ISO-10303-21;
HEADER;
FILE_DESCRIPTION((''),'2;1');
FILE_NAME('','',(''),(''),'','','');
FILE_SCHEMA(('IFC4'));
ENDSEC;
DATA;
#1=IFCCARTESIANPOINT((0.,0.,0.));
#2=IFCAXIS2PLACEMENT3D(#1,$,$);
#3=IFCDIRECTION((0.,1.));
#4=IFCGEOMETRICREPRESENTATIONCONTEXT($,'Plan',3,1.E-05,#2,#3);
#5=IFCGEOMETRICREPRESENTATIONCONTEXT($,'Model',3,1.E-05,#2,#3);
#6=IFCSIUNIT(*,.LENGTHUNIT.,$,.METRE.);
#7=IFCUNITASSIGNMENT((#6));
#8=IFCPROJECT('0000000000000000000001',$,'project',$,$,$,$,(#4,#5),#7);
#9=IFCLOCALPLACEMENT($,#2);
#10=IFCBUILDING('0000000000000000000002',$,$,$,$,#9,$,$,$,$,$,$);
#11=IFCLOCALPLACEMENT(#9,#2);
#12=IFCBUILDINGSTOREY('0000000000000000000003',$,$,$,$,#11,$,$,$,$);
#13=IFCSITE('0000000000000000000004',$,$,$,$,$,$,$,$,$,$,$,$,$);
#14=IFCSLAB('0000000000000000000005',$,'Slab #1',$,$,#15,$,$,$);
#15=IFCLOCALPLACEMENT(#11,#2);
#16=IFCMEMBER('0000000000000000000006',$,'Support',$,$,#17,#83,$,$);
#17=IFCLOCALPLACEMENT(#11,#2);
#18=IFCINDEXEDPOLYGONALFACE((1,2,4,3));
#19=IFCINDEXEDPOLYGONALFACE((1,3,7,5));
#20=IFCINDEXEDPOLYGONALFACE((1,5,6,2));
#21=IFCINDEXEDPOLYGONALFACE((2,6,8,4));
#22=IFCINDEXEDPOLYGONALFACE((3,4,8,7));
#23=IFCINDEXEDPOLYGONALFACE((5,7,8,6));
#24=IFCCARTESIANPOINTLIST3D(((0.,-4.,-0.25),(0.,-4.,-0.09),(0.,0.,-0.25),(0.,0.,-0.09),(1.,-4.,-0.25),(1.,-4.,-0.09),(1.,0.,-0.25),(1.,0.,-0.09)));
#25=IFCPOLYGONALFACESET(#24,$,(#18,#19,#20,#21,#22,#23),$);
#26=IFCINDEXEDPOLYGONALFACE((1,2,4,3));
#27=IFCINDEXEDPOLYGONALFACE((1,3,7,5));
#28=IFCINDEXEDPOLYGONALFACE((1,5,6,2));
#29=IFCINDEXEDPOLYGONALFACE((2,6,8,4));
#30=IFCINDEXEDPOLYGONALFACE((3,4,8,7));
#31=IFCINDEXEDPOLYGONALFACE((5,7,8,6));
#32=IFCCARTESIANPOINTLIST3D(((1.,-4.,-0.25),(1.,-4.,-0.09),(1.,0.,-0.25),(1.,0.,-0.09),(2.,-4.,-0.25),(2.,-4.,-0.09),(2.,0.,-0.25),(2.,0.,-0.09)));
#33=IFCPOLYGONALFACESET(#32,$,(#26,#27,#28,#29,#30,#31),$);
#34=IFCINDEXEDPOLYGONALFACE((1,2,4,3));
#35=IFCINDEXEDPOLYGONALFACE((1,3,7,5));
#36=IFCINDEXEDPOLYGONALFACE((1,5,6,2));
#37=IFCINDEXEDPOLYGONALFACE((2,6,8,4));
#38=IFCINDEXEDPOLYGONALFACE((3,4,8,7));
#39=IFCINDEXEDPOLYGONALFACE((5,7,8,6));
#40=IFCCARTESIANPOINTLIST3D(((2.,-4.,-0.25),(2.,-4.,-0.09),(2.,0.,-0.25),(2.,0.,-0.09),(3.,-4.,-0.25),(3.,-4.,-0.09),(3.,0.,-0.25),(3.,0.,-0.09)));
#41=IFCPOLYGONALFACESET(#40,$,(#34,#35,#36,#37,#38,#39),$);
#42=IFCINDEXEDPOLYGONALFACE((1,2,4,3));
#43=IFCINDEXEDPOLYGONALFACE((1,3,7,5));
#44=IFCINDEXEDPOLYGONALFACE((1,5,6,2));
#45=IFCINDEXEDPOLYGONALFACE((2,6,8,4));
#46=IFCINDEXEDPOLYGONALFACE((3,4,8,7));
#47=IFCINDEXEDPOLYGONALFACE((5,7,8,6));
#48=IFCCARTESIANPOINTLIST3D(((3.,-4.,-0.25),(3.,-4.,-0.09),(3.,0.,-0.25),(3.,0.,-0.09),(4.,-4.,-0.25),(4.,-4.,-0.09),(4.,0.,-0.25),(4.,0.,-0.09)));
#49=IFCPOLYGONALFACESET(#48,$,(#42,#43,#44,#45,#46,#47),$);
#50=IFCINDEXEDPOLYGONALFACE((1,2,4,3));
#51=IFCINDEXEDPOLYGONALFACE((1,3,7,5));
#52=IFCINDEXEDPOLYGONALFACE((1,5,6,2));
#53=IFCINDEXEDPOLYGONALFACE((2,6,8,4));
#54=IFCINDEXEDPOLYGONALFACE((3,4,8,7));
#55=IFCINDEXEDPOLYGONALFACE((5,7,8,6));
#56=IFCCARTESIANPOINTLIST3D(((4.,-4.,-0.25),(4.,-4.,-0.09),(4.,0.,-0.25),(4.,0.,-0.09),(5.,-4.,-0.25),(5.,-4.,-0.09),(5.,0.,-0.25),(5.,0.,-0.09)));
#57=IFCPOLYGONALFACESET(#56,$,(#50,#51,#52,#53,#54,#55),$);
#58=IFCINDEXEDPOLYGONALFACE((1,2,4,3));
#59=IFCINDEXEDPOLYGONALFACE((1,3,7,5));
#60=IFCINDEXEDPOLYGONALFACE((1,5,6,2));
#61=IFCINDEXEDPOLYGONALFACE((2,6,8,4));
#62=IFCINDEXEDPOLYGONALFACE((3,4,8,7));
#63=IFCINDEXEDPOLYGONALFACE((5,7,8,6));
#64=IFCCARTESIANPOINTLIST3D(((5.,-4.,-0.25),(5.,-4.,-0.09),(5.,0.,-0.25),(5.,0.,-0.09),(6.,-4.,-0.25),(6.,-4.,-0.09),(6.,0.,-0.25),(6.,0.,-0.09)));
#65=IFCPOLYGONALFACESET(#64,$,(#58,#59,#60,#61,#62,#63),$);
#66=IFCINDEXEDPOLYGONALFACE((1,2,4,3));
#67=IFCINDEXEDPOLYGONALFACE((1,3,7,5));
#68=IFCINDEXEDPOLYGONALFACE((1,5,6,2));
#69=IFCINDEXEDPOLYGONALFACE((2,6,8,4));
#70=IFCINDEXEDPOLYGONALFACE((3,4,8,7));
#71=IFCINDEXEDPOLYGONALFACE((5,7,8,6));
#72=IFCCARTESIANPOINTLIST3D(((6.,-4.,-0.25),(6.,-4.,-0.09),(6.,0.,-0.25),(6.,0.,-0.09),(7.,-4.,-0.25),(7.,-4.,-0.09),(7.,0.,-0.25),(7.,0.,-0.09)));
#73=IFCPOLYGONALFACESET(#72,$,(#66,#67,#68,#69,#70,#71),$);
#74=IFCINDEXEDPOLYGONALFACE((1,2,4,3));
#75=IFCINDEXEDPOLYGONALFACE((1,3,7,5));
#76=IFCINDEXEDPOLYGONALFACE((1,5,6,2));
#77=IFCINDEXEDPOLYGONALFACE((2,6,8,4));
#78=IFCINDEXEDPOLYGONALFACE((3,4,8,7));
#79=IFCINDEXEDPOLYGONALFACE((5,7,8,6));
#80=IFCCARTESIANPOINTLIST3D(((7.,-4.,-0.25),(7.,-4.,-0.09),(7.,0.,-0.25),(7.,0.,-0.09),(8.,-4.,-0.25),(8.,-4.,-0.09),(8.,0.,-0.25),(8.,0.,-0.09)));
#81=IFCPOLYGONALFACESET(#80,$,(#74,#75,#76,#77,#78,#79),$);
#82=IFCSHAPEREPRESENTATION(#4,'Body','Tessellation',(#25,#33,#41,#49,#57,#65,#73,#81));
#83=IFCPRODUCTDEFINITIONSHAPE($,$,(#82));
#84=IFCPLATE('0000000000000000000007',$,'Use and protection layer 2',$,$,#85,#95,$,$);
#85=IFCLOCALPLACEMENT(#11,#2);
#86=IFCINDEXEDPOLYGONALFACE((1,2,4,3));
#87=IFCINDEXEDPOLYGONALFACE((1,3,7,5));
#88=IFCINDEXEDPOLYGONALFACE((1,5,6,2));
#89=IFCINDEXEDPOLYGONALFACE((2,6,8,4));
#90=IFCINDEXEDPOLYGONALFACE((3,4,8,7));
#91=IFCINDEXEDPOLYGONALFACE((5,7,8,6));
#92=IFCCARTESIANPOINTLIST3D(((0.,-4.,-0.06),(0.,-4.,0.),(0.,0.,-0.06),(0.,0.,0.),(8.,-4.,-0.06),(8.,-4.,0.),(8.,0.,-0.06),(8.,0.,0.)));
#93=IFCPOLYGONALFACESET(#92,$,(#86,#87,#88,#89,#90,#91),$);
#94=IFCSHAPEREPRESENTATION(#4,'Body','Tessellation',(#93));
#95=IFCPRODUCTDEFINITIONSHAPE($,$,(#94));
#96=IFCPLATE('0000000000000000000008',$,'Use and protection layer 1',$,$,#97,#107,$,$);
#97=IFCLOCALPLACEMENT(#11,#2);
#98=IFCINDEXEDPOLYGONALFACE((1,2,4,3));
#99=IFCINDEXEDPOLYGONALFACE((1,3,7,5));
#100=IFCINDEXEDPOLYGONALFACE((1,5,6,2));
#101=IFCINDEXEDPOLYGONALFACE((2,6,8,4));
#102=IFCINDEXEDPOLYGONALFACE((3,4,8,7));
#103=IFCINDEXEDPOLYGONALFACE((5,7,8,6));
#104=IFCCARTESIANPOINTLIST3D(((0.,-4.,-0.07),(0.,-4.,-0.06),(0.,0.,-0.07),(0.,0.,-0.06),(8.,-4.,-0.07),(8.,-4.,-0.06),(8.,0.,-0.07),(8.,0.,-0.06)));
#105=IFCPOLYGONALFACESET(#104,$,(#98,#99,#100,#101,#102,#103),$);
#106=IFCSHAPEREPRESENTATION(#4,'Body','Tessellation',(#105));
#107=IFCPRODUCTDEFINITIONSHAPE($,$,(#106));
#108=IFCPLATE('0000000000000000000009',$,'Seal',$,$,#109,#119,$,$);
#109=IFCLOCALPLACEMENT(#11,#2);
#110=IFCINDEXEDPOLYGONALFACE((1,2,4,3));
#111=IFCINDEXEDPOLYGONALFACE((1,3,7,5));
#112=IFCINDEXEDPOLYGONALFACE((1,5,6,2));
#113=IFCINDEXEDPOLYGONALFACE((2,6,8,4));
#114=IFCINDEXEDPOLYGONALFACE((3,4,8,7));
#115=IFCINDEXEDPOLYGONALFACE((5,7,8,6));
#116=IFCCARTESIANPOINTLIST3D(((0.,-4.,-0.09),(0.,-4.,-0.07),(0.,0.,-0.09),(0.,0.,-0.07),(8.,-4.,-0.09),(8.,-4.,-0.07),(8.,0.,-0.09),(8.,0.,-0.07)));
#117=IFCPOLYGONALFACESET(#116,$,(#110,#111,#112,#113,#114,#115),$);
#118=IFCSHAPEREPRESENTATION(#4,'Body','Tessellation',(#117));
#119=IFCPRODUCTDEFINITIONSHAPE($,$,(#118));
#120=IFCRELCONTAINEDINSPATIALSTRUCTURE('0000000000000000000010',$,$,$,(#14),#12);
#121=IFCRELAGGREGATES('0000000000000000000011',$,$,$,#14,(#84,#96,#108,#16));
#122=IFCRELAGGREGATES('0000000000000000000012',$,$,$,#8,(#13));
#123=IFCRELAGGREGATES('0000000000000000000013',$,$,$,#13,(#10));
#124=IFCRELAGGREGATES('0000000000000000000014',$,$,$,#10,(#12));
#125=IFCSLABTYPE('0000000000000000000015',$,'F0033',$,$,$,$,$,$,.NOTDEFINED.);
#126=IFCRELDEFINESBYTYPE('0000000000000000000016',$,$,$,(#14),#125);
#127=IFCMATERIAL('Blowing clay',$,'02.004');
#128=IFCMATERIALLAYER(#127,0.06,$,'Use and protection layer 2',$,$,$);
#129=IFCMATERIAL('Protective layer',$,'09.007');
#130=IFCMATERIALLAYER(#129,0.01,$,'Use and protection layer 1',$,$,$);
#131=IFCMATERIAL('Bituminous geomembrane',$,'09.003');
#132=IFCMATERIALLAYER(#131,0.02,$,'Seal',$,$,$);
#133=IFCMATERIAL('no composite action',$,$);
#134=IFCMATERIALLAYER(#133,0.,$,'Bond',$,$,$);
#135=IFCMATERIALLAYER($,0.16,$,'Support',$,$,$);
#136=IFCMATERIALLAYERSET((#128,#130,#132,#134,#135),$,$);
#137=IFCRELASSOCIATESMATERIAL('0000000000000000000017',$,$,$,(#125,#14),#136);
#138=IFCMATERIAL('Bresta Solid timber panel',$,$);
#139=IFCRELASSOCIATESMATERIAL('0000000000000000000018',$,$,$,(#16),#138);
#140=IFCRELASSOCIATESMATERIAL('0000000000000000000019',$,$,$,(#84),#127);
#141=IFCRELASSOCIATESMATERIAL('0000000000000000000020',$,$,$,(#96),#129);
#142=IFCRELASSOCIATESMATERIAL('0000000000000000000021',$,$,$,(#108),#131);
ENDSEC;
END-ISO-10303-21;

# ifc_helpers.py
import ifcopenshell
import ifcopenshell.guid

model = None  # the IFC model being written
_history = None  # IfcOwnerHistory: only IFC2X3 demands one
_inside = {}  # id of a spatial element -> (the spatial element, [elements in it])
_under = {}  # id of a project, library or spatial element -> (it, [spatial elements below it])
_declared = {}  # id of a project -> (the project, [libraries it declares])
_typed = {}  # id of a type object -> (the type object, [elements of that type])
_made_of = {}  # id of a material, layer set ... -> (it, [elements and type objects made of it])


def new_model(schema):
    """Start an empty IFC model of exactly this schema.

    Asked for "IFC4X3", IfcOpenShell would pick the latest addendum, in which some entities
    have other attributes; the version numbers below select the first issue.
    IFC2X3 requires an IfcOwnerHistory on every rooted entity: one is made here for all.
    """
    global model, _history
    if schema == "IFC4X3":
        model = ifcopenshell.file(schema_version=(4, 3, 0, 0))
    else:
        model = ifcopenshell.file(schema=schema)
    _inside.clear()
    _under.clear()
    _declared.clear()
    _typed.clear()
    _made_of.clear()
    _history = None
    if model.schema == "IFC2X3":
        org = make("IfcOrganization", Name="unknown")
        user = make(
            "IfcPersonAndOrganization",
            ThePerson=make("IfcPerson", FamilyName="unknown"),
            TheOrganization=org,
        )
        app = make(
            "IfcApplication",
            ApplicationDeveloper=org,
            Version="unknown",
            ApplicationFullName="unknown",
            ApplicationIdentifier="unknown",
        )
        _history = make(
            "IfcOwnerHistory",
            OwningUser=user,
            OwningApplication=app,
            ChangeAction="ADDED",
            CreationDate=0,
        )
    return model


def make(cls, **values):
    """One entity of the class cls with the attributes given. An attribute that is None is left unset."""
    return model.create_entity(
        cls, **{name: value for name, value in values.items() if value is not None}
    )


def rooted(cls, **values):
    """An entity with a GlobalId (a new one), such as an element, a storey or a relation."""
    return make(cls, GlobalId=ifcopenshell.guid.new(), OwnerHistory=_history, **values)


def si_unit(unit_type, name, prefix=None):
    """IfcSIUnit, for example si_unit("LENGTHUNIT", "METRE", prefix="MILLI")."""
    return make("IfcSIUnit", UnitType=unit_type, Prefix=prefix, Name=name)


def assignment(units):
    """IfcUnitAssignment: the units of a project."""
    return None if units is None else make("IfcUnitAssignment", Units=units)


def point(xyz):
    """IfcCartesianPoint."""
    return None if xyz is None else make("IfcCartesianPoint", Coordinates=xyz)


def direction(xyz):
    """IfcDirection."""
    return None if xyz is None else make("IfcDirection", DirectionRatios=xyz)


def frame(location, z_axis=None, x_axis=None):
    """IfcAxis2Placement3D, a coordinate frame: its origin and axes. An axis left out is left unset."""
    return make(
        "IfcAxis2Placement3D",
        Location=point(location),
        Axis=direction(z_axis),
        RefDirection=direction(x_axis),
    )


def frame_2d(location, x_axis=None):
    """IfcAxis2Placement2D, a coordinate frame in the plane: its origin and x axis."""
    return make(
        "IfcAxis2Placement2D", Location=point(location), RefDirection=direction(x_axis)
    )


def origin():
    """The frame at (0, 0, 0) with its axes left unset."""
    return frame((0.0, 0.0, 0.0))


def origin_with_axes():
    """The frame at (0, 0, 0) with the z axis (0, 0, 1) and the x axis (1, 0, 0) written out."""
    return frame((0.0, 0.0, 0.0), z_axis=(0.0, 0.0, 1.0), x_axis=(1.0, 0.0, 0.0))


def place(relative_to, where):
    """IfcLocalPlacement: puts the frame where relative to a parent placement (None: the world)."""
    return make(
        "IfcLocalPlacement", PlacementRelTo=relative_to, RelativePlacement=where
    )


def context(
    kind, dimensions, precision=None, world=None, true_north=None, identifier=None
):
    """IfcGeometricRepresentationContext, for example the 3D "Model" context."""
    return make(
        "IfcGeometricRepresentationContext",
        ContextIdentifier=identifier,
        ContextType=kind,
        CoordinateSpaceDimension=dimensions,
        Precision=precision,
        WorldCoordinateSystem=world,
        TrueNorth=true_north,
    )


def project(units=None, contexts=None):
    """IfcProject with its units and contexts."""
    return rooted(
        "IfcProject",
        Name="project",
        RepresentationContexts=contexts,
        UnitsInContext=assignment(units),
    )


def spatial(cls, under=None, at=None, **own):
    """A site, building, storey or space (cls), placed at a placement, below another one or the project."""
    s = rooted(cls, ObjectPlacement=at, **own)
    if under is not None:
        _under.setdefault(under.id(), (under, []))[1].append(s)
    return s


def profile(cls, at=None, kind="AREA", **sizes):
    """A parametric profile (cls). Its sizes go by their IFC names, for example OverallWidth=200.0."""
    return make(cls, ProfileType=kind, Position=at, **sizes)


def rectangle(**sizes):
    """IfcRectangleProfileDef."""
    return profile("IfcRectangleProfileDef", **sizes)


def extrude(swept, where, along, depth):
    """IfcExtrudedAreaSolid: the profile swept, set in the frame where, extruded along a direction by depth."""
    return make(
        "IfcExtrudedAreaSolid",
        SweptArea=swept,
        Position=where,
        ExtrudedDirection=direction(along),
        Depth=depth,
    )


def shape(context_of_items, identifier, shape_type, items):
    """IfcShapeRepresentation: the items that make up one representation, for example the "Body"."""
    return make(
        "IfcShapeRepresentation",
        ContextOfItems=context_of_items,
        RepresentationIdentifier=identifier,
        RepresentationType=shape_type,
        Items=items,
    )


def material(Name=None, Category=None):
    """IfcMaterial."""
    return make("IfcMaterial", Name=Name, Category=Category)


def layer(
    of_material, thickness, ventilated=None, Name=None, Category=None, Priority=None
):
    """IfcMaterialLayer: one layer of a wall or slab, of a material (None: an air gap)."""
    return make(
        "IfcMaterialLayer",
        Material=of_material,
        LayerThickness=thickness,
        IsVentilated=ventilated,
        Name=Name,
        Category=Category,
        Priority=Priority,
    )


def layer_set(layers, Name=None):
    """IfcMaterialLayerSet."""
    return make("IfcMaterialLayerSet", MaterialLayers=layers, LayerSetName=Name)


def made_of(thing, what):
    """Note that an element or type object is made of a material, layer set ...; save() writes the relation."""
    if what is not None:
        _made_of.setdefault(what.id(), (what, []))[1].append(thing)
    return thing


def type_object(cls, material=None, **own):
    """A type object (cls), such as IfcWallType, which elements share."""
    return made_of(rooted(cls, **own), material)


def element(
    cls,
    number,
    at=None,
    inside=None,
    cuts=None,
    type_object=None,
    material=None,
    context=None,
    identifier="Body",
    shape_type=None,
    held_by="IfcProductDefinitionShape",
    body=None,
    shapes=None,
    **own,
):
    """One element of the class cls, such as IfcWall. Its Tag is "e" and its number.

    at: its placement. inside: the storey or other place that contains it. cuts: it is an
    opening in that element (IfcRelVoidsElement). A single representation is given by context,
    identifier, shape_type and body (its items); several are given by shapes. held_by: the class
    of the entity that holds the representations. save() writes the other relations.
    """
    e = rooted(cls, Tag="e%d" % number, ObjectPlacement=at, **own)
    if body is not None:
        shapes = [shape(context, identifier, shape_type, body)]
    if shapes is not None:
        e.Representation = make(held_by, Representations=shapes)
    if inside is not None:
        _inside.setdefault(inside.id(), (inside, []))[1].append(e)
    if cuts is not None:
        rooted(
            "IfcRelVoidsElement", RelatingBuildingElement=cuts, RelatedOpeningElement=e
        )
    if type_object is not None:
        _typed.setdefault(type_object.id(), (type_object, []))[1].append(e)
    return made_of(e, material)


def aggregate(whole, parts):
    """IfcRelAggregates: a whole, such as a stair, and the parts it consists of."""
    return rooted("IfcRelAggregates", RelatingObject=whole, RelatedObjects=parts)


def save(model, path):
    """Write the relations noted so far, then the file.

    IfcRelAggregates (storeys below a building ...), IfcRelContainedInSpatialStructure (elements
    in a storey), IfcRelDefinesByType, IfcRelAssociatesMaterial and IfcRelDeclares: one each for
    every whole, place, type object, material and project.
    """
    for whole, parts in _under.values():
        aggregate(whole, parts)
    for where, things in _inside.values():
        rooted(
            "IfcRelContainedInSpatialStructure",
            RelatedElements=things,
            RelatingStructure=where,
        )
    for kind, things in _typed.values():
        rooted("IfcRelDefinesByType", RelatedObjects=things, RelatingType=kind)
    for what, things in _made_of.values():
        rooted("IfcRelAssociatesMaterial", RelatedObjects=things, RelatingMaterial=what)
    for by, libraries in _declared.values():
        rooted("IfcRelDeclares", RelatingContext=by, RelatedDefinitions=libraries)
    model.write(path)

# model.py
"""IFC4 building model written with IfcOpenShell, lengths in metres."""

from ifc_helpers import new_model, si_unit, direction, frame, frame_2d, origin, origin_with_axes, place, context, project, spatial, rectangle, extrude, material, layer, layer_set, type_object, element, aggregate, save


model = new_model("IFC4")

# Units and contexts
plan_context = context("Plan", 3, precision=1e-05, world=origin(), true_north=direction((0.0, 1.0)))
model_context = context("Model", 3, precision=1e-05, world=origin(), true_north=direction((0.0, 1.0)))
ifc_project = project(units=[si_unit("LENGTHUNIT", "METRE")], contexts=[plan_context, model_context])

# Site, building, storey
site = spatial("IfcSite", under=ifc_project)
building_placement = place(None, origin())
building = spatial("IfcBuilding", under=site, at=building_placement)
storey_placement = place(building_placement, origin())
storey = spatial("IfcBuildingStorey", under=building, at=storey_placement)

# Slab, member, plates
ifc_material_1 = material(Name="Blowing clay", Category="02.004")
ifc_layer_1 = layer(ifc_material_1, 0.06, Name="Use and protection layer 2")
ifc_material_2 = material(Name="Protective layer", Category="09.007")
ifc_layer_2 = layer(ifc_material_2, 0.01, Name="Use and protection layer 1")
ifc_material_3 = material(Name="Bituminous geomembrane", Category="09.003")
ifc_layer_3 = layer(ifc_material_3, 0.02, Name="Seal")
ifc_material_4 = material(Name="no composite action")
ifc_layer_4 = layer(ifc_material_4, 0.0, Name="Bond")
ifc_layer_5 = layer(None, 0.16, Name="Support")
ifc_layer_set = layer_set([ifc_layer_1, ifc_layer_2, ifc_layer_3, ifc_layer_4, ifc_layer_5])
slab_type = type_object("IfcSlabType", Name="F0033", PredefinedType="NOTDEFINED", material=ifc_layer_set)
slab_placement = place(None, frame((0.0, 0.0, 0.0), z_axis=(0.0, 0.0, -1.0), x_axis=(1.0, 0.0, 0.0)))
slab = element("IfcSlab", 1, at=slab_placement, inside=storey, type_object=slab_type, material=ifc_layer_set, Name="Slab #1")
ifc_material_5 = material(Name="Bresta Solid timber panel")
member_placement = place(slab_placement, origin())
member = element("IfcMember", 2, at=member_placement, material=ifc_material_5, Name="Support", context=plan_context, shape_type="SweptSolid", body=[
    extrude(rectangle(XDim=1.0, YDim=0.16, at=frame_2d((0.5, 0.08), x_axis=(1.0, 0.0))), frame((0.0, 4.0, 0.09), z_axis=(0.0, -1.0, 0.0), x_axis=(1.0, 0.0, 0.0)), (0.0, 0.0, 1.0), 4.0),
    extrude(rectangle(XDim=1.0, YDim=0.16, at=frame_2d((0.5, 0.08), x_axis=(1.0, 0.0))), frame((1.0, 4.0, 0.09), z_axis=(0.0, -1.0, 0.0), x_axis=(1.0, 0.0, 0.0)), (0.0, 0.0, 1.0), 4.0),
    extrude(rectangle(XDim=1.0, YDim=0.16, at=frame_2d((0.5, 0.08), x_axis=(1.0, 0.0))), frame((2.0, 4.0, 0.09), z_axis=(0.0, -1.0, 0.0), x_axis=(1.0, 0.0, 0.0)), (0.0, 0.0, 1.0), 4.0),
    extrude(rectangle(XDim=1.0, YDim=0.16, at=frame_2d((0.5, 0.08), x_axis=(1.0, 0.0))), frame((3.0, 4.0, 0.09), z_axis=(0.0, -1.0, 0.0), x_axis=(1.0, 0.0, 0.0)), (0.0, 0.0, 1.0), 4.0),
    extrude(rectangle(XDim=1.0, YDim=0.16, at=frame_2d((0.5, 0.08), x_axis=(1.0, 0.0))), frame((4.0, 4.0, 0.09), z_axis=(0.0, -1.0, 0.0), x_axis=(1.0, 0.0, 0.0)), (0.0, 0.0, 1.0), 4.0),
    extrude(rectangle(XDim=1.0, YDim=0.16, at=frame_2d((0.5, 0.08), x_axis=(1.0, 0.0))), frame((5.0, 4.0, 0.09), z_axis=(0.0, -1.0, 0.0), x_axis=(1.0, 0.0, 0.0)), (0.0, 0.0, 1.0), 4.0),
    extrude(rectangle(XDim=1.0, YDim=0.16, at=frame_2d((0.5, 0.08), x_axis=(1.0, 0.0))), frame((6.0, 4.0, 0.09), z_axis=(0.0, -1.0, 0.0), x_axis=(1.0, 0.0, 0.0)), (0.0, 0.0, 1.0), 4.0),
    extrude(rectangle(XDim=1.0, YDim=0.16, at=frame_2d((0.5, 0.08), x_axis=(1.0, 0.0))), frame((7.0, 4.0, 0.09), z_axis=(0.0, -1.0, 0.0), x_axis=(1.0, 0.0, 0.0)), (0.0, 0.0, 1.0), 4.0),
])
plate_1_placement = place(slab_placement, origin())
plate_1 = element("IfcPlate", 3, at=plate_1_placement, material=ifc_material_1, Name="Use and protection layer 2", context=plan_context, shape_type="SweptSolid", body=[
    extrude(rectangle(XDim=8.0, YDim=4.0, at=frame_2d((4.0, 2.0), x_axis=(1.0, 0.0))), origin_with_axes(), (0.0, 0.0, 1.0), 0.06),
])
plate_2_placement = place(slab_placement, origin())
plate_2 = element("IfcPlate", 4, at=plate_2_placement, material=ifc_material_2, Name="Use and protection layer 1", context=plan_context, shape_type="SweptSolid", body=[
    extrude(rectangle(XDim=8.0, YDim=4.0, at=frame_2d((4.0, 2.0), x_axis=(1.0, 0.0))), frame((0.0, 0.0, 0.06), z_axis=(0.0, 0.0, 1.0), x_axis=(1.0, 0.0, 0.0)), (0.0, 0.0, 1.0), 0.01),
])
plate_3_placement = place(slab_placement, origin())
plate_3 = element("IfcPlate", 5, at=plate_3_placement, material=ifc_material_3, Name="Seal", context=plan_context, shape_type="SweptSolid", body=[
    extrude(rectangle(XDim=8.0, YDim=4.0, at=frame_2d((4.0, 2.0), x_axis=(1.0, 0.0))), frame((0.0, 0.0, 0.07), z_axis=(0.0, 0.0, 1.0), x_axis=(1.0, 0.0, 0.0)), (0.0, 0.0, 1.0), 0.02),
])
aggregate(slab, [plate_1, plate_2, plate_3, member])

save(model, "model.ifc")
